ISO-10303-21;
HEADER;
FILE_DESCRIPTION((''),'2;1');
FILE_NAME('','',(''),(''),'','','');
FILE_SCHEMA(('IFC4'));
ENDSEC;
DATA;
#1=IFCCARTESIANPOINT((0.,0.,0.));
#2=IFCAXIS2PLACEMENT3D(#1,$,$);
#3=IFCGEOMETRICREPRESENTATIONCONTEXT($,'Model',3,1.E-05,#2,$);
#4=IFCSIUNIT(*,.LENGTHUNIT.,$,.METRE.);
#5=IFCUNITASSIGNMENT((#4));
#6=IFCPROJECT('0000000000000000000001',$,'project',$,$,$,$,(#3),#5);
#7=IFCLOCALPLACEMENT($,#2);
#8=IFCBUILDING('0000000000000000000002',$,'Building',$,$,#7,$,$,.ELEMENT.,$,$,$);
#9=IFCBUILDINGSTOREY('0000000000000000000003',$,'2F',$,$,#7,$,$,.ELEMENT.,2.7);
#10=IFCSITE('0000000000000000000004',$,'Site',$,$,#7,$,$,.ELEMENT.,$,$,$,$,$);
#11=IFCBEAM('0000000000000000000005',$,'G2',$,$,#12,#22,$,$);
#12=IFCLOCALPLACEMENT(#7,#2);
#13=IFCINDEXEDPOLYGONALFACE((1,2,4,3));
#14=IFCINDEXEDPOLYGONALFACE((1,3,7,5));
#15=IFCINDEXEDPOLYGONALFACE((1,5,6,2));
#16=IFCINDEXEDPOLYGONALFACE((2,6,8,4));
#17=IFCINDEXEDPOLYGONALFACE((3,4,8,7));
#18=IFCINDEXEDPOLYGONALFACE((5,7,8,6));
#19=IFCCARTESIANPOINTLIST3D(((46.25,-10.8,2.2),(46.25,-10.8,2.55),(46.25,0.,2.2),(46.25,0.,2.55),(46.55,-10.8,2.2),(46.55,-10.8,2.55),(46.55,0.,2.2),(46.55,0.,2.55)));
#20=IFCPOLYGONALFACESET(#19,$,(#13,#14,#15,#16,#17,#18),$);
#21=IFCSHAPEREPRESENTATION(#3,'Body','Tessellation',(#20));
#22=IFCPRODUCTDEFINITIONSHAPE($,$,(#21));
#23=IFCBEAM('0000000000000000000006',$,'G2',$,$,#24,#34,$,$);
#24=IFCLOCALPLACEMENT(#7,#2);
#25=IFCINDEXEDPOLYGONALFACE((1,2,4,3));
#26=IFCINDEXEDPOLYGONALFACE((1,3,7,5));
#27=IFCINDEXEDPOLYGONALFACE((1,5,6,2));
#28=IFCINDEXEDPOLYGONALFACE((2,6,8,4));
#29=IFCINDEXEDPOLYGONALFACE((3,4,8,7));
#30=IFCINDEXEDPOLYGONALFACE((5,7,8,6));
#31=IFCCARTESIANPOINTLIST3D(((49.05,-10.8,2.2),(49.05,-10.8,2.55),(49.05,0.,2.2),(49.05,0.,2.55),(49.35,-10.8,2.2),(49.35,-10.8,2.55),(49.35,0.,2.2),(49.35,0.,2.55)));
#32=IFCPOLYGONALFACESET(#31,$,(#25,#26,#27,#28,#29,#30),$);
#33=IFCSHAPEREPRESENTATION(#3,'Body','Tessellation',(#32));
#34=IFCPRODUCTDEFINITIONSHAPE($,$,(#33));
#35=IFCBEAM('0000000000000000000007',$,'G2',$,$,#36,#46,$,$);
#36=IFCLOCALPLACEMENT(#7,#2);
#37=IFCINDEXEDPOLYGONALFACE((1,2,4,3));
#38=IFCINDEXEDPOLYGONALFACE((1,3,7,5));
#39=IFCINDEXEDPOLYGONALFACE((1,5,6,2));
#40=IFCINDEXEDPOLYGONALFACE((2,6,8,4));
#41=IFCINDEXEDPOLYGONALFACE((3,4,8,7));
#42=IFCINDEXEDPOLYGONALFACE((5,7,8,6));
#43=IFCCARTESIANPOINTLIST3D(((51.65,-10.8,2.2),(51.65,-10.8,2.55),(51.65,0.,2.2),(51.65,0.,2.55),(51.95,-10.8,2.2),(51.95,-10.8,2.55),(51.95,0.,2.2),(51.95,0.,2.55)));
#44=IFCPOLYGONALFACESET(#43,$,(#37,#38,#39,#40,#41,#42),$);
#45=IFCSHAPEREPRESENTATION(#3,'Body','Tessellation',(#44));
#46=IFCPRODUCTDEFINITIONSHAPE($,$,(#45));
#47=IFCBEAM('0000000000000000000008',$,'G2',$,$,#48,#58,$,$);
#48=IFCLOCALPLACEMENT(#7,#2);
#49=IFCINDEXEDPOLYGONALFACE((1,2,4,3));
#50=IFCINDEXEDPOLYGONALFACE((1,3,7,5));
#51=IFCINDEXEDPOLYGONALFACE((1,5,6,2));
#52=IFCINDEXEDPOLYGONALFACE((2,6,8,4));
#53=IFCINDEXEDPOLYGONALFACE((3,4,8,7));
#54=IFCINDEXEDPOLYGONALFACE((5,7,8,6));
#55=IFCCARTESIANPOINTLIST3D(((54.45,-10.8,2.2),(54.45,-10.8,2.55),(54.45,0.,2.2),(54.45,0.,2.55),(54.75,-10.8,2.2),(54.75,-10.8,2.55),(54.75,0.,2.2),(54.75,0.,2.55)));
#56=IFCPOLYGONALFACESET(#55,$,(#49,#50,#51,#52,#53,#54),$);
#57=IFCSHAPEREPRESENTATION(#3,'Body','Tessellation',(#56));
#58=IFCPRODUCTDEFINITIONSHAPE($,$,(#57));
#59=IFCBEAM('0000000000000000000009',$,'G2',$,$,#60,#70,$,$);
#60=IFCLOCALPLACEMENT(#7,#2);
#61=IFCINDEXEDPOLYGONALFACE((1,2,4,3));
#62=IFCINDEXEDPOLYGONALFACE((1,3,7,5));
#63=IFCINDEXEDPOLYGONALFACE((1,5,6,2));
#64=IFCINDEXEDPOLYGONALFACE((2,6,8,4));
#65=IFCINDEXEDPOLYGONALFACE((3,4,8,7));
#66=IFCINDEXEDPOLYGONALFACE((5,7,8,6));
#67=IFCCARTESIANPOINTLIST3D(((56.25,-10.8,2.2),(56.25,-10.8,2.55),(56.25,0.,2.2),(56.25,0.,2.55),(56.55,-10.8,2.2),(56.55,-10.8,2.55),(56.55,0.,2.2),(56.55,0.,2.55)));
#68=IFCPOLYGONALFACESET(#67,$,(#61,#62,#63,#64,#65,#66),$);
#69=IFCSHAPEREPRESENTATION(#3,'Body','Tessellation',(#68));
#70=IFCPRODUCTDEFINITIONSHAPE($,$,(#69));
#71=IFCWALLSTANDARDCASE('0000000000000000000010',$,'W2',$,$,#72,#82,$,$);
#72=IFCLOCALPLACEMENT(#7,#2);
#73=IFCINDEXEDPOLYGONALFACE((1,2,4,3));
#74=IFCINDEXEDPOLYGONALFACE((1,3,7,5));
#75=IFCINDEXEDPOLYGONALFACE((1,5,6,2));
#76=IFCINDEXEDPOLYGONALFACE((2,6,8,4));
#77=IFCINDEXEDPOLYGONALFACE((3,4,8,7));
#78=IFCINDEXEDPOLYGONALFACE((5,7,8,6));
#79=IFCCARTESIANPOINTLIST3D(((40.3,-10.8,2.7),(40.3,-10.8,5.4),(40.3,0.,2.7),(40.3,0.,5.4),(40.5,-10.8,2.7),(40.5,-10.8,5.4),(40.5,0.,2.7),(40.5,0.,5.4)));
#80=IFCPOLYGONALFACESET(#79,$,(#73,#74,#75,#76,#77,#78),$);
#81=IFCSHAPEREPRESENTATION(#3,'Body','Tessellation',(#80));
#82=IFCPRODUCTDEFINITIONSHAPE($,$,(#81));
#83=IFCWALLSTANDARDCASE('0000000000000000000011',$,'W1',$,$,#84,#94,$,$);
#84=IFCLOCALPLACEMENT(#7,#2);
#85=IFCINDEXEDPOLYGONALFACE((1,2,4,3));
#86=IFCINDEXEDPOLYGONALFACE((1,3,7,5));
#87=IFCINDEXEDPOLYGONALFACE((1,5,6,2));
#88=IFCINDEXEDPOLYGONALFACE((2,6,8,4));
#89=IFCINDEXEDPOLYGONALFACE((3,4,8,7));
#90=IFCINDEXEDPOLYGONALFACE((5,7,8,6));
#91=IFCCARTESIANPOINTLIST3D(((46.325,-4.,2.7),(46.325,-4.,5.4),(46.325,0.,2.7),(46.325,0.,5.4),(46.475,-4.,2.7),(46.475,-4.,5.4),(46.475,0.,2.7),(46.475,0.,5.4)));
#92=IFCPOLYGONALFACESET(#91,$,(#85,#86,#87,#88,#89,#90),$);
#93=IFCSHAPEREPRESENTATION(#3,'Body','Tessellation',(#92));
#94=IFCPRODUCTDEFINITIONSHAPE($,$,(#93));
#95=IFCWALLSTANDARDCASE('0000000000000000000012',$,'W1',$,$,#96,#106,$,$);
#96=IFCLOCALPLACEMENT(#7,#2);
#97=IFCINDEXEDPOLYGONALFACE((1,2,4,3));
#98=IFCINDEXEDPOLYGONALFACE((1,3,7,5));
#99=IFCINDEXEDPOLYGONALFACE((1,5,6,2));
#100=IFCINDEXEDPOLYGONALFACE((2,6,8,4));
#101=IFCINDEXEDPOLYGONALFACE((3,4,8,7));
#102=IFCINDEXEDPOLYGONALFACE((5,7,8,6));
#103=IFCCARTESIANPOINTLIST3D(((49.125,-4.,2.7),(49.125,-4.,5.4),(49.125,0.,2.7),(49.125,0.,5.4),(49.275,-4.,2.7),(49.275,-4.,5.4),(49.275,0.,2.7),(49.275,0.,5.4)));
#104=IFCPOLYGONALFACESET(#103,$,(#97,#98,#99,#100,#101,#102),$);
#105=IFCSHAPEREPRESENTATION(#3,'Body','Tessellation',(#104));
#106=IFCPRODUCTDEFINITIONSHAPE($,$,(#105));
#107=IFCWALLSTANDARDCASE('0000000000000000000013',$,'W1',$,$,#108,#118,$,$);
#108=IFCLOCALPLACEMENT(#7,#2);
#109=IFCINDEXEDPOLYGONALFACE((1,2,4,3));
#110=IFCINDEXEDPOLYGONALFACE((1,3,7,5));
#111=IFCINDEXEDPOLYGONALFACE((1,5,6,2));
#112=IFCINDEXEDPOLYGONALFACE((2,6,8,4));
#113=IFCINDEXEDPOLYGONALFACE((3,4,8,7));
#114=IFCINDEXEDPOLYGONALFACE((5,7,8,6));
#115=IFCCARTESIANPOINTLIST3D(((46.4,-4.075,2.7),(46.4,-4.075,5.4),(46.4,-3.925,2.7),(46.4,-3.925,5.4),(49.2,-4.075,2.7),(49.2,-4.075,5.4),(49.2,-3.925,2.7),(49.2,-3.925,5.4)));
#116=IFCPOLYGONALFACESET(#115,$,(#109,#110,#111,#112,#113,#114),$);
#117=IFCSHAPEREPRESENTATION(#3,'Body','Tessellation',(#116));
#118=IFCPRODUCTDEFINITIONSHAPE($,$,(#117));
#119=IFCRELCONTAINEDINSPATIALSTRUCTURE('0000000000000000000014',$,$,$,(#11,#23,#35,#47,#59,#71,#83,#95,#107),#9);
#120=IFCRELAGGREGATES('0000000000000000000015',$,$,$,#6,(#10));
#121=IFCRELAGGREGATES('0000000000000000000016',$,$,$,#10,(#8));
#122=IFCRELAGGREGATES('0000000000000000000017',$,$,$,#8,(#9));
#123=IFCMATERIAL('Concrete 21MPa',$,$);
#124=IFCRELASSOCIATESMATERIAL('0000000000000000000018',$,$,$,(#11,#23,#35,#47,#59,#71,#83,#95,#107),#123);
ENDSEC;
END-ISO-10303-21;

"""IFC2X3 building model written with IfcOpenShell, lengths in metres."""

from ifc_helpers import new_model, si_unit, frame, origin, origin_2d, place, context, project, spatial, rectangle, extrude, material, element, save


model = new_model("IFC2X3")

# Units and contexts
model_context = context("Model", 3, precision=1e-05, world=origin())
ifc_project = project(units=[si_unit("LENGTHUNIT", "METRE")], contexts=[model_context])

# Site, building, storey
placement = place(None, origin())
site = spatial("IfcSite", under=ifc_project, at=placement, Name="Site", CompositionType="ELEMENT")
building = spatial("IfcBuilding", under=site, at=placement, Name="Building", CompositionType="ELEMENT")
storey = spatial("IfcBuildingStorey", under=building, at=placement, Name="2F", CompositionType="ELEMENT", Elevation=2.7)

# Shared definitions
ifc_material = material(Name="Concrete 21MPa")

# Beams
for number, where, name in (
    (1, (46.4, -5.4, 2.2), "G2"),
    (2, (49.2, -5.4, 2.2), "G2"),
    (3, (51.8, -5.4, 2.2), "G2"),
    (4, (54.6, -5.4, 2.2), "G2"),
    (5, (56.4, -5.4, 2.2), "G2"),
):
    element("IfcBeam", number, at=place(None, frame(where)), inside=storey, material=ifc_material, Name=name, context=model_context, shape_type="SweptSolid", body=[
        extrude(rectangle(XDim=0.3, YDim=10.8, at=origin_2d()), origin(), (0.0, 0.0, 1.0), 0.35),
    ])

# Walls
wall_1_placement = place(None, frame((40.4, -5.4, 2.7)))
element("IfcWallStandardCase", 6, at=wall_1_placement, inside=storey, material=ifc_material, Name="W2", context=model_context, shape_type="SweptSolid", body=[
    extrude(rectangle(XDim=0.2, YDim=10.8, at=origin_2d()), origin(), (0.0, 0.0, 1.0), 2.7),
])
for number, where, name in (
    (7, (46.4, -2.0, 2.7), "W1"),
    (8, (49.2, -2.0, 2.7), "W1"),
):
    element("IfcWallStandardCase", number, at=place(None, frame(where)), inside=storey, material=ifc_material, Name=name, context=model_context, shape_type="SweptSolid", body=[
        extrude(rectangle(XDim=0.15, YDim=4.0, at=origin_2d()), origin(), (0.0, 0.0, 1.0), 2.7),
    ])
wall_2_placement = place(None, frame((47.8, -4.0, 2.7)))
element("IfcWallStandardCase", 9, at=wall_2_placement, inside=storey, material=ifc_material, Name="W1", context=model_context, shape_type="SweptSolid", body=[
    extrude(rectangle(XDim=2.8, YDim=0.15, at=origin_2d()), origin(), (0.0, 0.0, 1.0), 2.7),
])

save(model, "model.ifc")
